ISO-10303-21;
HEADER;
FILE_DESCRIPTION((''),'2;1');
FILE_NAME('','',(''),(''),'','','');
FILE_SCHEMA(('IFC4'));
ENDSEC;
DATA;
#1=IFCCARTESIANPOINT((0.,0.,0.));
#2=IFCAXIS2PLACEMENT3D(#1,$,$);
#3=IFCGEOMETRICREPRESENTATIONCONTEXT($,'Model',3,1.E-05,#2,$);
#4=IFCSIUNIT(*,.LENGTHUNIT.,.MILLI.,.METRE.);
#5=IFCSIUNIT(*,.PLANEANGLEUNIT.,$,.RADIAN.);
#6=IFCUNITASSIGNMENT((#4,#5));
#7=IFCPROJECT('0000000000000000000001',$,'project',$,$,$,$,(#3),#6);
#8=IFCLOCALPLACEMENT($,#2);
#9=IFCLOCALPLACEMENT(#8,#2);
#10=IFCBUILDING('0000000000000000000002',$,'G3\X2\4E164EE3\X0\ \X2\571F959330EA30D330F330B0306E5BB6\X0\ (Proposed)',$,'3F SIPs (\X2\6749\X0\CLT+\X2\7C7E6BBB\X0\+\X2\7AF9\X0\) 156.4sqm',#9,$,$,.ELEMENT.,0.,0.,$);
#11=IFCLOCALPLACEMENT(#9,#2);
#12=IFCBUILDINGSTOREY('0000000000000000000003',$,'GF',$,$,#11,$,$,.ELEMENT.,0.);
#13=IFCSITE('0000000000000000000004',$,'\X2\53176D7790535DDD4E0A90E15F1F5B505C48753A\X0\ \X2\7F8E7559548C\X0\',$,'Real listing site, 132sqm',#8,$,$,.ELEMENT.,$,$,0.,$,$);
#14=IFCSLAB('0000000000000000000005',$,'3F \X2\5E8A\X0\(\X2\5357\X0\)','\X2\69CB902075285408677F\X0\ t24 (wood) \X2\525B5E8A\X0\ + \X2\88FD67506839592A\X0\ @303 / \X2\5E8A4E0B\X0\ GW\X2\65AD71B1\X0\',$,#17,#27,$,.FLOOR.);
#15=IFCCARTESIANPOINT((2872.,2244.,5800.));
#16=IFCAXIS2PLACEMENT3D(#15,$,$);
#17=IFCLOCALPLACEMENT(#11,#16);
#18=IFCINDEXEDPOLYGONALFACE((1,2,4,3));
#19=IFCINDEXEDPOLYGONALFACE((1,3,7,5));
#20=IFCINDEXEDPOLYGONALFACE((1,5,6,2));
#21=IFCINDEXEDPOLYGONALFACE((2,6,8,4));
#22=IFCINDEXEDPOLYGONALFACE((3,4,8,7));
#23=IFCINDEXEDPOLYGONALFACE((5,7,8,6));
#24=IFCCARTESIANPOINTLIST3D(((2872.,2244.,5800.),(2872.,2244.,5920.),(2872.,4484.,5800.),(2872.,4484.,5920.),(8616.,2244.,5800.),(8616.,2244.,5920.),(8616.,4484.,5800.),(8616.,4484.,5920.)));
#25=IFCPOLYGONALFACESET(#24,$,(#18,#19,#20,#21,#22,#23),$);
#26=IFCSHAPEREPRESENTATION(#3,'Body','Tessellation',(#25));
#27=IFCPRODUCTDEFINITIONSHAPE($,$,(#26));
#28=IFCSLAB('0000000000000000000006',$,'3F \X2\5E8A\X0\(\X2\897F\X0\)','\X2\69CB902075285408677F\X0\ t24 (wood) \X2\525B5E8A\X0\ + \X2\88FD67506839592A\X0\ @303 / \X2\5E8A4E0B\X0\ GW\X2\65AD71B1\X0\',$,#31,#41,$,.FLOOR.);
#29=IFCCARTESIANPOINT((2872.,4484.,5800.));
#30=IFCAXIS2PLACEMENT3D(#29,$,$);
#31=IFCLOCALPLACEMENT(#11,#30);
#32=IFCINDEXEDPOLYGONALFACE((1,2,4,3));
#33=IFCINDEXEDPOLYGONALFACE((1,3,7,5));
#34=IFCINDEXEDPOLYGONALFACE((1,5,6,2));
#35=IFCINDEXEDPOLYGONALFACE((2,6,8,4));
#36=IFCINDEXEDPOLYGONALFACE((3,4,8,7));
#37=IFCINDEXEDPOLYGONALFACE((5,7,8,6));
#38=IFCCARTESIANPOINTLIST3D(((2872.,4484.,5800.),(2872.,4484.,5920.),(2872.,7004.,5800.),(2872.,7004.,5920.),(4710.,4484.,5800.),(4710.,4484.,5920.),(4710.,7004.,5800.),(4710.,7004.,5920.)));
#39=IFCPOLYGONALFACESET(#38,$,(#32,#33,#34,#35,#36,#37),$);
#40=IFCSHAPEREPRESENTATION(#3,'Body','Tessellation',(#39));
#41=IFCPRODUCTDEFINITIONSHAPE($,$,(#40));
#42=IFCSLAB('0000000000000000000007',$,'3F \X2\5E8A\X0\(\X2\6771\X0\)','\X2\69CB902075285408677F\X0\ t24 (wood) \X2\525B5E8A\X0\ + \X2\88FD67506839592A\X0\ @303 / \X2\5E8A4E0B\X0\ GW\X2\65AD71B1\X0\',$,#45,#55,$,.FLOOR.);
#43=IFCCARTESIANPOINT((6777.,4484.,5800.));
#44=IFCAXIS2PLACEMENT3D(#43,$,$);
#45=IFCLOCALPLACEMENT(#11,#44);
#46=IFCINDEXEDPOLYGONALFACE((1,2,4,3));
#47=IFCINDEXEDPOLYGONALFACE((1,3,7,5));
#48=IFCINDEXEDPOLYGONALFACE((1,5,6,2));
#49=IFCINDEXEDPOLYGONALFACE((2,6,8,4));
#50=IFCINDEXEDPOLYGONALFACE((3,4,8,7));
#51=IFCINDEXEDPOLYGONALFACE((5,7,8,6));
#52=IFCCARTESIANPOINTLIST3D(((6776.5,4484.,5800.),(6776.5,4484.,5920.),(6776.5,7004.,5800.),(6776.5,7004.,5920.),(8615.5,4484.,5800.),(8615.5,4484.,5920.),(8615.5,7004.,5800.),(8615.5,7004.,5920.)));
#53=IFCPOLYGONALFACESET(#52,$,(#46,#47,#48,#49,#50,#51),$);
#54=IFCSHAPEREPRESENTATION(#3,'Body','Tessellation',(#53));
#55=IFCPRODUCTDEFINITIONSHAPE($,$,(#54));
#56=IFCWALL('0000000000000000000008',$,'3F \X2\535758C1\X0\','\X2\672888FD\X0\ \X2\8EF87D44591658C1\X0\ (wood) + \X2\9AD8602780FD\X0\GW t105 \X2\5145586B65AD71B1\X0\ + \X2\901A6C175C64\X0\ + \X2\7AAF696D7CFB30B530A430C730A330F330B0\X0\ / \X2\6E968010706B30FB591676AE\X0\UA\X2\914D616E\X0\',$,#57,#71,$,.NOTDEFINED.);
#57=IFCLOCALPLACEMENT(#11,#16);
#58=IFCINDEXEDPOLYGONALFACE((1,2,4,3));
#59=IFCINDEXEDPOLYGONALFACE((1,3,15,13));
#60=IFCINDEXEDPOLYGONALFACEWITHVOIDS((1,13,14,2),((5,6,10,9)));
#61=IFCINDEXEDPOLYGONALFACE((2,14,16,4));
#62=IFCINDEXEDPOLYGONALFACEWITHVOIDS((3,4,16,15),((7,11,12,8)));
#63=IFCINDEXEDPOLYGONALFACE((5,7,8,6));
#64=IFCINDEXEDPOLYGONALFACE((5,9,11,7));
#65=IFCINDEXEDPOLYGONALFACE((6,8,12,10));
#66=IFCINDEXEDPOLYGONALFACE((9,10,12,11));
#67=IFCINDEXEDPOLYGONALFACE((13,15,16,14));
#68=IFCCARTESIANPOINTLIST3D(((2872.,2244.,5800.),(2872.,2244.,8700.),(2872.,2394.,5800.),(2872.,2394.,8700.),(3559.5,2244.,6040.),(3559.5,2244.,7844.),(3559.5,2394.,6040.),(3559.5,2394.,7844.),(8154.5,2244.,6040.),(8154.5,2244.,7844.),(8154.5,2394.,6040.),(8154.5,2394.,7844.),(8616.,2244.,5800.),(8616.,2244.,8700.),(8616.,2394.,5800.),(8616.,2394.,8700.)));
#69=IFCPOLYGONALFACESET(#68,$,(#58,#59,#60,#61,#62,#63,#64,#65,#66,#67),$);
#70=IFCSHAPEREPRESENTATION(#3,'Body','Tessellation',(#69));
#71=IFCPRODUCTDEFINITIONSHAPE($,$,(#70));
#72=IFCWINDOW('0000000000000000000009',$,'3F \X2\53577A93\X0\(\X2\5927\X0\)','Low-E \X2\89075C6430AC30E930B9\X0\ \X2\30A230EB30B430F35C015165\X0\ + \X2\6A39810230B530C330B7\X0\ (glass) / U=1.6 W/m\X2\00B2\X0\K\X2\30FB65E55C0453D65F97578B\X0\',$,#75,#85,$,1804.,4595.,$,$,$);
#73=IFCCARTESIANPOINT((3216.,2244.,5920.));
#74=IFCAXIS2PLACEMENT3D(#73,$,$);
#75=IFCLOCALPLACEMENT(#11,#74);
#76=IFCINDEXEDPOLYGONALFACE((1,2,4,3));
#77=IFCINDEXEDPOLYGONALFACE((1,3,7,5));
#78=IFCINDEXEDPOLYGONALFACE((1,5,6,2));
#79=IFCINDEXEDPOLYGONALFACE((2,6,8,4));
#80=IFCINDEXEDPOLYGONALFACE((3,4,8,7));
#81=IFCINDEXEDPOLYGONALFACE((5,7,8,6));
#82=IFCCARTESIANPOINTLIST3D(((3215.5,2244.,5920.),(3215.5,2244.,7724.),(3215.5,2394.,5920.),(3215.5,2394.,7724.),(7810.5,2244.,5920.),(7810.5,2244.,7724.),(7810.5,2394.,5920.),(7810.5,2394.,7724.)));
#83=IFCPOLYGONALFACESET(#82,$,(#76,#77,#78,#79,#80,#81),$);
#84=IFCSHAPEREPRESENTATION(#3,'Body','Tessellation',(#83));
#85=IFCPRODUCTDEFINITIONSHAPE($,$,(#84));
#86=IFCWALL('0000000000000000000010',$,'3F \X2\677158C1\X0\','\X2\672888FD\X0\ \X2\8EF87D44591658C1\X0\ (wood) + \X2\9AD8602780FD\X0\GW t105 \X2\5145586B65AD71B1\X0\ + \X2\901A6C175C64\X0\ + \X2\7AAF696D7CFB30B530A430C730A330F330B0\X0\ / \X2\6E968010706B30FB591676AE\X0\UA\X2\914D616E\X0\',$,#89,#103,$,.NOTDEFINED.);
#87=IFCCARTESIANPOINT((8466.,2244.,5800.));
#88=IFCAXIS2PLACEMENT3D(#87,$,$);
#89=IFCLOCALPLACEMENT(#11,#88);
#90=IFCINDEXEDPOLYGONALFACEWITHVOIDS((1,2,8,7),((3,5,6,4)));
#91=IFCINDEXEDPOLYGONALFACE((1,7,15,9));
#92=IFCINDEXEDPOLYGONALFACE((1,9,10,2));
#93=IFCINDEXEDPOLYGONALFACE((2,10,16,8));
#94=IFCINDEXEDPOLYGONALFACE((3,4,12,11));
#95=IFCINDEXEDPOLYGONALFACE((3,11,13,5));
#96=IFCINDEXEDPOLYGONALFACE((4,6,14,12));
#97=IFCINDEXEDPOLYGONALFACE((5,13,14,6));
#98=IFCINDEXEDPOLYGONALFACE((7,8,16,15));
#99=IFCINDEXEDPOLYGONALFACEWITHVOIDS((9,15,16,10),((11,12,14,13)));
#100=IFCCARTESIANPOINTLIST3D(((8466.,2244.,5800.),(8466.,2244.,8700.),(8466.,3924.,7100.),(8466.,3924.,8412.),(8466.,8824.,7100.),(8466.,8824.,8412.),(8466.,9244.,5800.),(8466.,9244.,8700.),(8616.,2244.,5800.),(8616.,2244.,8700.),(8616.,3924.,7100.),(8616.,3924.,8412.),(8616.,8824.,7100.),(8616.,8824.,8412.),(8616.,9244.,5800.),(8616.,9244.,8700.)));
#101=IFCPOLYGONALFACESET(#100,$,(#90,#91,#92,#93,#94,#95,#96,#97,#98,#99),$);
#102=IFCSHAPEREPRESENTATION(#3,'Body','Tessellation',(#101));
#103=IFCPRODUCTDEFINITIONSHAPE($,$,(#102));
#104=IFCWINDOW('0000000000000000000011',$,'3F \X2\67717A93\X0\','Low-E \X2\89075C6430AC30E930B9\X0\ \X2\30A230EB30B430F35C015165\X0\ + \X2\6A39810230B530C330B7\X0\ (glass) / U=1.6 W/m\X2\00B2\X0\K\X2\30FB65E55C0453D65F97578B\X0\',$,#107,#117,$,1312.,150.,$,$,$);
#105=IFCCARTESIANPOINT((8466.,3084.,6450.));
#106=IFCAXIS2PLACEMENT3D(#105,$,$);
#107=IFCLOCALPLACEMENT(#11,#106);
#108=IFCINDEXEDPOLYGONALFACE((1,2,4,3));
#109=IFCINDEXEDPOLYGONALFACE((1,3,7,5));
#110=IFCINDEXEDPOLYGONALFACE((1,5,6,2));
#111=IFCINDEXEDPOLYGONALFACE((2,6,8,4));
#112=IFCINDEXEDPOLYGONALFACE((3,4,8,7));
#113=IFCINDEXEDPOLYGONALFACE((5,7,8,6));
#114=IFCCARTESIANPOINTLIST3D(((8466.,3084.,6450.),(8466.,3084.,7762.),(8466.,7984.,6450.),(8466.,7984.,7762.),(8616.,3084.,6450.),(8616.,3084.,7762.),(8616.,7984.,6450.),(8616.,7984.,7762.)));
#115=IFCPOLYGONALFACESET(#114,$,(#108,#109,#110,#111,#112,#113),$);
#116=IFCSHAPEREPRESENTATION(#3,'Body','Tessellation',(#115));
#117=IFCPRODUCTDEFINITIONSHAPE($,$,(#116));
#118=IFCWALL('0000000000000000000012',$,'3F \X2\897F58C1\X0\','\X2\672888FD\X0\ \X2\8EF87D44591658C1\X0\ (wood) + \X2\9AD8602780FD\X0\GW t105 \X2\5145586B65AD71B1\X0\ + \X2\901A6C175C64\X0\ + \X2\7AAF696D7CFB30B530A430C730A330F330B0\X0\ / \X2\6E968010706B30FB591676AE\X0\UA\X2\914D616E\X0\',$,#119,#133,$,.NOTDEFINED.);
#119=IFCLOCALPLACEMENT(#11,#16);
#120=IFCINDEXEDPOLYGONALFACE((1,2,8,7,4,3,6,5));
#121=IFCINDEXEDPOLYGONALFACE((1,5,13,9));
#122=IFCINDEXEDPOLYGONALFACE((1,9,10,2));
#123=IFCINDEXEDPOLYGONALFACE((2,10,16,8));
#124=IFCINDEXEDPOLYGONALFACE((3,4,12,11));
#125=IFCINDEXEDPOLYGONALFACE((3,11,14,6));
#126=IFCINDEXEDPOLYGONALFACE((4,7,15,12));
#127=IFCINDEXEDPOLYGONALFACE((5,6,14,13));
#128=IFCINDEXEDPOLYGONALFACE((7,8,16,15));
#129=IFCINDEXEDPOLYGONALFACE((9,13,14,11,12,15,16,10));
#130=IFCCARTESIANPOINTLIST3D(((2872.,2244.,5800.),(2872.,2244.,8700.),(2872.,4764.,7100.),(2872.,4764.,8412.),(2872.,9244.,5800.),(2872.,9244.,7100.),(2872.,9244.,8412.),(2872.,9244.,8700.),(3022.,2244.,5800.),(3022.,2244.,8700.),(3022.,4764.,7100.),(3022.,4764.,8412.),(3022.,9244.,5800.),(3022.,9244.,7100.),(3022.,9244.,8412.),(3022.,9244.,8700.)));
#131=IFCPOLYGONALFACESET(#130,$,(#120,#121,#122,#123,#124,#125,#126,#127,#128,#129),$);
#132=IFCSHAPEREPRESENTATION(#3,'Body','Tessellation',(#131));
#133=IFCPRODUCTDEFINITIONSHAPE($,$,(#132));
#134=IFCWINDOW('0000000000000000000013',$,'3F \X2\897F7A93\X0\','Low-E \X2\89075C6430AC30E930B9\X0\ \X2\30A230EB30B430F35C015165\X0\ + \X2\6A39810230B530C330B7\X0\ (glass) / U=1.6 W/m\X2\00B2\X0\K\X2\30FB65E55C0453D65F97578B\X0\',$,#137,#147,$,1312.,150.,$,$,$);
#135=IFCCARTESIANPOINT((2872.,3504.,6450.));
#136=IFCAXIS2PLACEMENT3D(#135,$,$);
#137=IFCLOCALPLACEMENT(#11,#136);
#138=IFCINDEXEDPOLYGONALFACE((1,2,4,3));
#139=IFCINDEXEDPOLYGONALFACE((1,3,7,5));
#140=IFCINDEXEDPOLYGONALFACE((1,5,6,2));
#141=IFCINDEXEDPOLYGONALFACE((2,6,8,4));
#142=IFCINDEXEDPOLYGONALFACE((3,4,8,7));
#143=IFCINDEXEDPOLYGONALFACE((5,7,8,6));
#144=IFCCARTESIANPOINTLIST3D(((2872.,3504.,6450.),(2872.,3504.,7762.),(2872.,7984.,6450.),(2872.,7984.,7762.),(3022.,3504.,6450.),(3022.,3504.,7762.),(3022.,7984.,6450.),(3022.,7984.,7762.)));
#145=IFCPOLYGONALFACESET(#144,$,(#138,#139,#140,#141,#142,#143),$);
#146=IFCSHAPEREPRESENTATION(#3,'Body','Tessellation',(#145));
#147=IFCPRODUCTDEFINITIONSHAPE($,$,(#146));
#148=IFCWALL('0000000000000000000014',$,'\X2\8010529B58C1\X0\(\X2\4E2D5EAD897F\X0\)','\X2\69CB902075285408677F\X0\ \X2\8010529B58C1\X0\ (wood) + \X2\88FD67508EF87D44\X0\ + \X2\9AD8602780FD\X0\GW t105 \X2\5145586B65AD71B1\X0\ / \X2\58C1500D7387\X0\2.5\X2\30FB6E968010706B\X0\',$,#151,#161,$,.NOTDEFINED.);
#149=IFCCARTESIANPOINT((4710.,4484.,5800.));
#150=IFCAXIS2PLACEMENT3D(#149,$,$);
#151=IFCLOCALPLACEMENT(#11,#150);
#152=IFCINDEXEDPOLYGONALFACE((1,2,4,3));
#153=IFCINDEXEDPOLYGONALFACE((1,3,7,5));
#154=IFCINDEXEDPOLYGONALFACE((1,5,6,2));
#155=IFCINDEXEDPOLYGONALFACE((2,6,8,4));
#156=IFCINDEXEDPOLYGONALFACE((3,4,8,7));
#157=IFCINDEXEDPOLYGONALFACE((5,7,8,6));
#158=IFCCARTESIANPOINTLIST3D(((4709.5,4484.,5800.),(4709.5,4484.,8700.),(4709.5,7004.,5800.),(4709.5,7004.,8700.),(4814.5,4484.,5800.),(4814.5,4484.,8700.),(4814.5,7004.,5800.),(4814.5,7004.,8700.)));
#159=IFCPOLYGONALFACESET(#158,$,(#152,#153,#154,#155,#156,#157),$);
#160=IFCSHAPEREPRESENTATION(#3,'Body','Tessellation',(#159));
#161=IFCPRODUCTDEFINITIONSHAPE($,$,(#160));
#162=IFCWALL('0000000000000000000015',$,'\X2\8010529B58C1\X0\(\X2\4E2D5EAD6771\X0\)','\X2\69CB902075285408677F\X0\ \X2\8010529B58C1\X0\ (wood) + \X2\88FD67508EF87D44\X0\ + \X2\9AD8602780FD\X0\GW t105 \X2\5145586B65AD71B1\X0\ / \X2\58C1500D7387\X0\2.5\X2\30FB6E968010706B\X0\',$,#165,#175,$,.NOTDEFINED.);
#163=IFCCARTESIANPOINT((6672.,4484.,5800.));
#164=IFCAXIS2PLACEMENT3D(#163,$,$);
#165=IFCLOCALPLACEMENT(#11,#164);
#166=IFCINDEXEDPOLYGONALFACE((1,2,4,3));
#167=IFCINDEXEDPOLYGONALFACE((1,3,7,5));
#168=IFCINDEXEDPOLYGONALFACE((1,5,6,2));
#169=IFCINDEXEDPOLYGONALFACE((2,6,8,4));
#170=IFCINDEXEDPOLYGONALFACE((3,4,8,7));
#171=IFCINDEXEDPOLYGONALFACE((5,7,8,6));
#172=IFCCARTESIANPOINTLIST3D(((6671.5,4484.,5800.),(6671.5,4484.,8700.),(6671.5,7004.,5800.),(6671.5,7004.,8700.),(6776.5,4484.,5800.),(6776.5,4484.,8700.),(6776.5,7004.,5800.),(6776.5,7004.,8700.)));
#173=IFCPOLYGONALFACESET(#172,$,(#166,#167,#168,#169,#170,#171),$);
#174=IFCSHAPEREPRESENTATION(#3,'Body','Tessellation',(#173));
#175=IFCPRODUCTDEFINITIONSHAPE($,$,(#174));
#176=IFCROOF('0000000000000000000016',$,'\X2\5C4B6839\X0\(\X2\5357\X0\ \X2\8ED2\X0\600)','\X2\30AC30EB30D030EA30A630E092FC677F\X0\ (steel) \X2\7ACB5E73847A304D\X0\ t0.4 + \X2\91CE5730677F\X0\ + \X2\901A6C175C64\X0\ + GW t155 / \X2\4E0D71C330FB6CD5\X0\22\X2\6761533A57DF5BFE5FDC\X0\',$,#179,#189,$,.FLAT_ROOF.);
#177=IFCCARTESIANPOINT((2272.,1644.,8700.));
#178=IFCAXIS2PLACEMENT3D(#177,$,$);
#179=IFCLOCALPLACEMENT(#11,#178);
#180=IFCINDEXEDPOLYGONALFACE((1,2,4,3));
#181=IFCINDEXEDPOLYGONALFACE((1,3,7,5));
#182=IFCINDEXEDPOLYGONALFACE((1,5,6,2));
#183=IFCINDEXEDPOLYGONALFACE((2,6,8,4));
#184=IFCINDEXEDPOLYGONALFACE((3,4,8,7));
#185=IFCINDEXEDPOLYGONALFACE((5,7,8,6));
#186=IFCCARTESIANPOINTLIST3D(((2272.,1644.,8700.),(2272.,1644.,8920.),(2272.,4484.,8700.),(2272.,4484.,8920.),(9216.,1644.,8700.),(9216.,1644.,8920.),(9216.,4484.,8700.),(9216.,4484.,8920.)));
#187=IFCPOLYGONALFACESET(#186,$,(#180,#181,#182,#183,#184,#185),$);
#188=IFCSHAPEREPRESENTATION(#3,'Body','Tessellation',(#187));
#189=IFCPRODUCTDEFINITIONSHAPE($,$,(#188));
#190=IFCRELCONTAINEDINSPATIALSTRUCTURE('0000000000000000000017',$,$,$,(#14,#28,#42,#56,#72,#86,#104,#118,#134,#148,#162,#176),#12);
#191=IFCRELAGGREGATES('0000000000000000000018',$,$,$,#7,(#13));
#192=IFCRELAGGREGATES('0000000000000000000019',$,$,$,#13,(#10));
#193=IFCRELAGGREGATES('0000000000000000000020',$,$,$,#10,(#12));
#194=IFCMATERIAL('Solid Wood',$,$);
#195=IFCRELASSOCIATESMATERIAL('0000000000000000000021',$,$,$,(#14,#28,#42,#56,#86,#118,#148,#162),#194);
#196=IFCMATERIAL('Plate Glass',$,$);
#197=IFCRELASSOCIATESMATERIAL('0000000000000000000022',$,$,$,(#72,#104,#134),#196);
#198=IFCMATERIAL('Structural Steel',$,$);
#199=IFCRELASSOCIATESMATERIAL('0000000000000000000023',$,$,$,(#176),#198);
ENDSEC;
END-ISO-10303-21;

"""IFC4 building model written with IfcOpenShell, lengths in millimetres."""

from ifc_helpers import new_model, si_unit, frame, frame_2d, origin, place, context, project, spatial, rectangle, extrude, material, element, fill, save


model = new_model("IFC4")

# Units and contexts
model_context = context("Model", 3, precision=1e-05, world=origin())
ifc_project = project(units=[si_unit("LENGTHUNIT", "METRE", prefix="MILLI"), si_unit("PLANEANGLEUNIT", "RADIAN")], contexts=[model_context])

# Site, building, storey
site_placement = place(None, origin())
site = spatial("IfcSite", under=ifc_project, at=site_placement, Name="北海道川上郡弟子屈町 美留和", ObjectType="Real listing site, 132sqm", CompositionType="ELEMENT", RefElevation=0.0)
building_placement = place(site_placement, origin())
building = spatial("IfcBuilding", under=site, at=building_placement, Name="G3世代 土間リビングの家 (Proposed)", ObjectType="3F SIPs (杉CLT+籾殻+竹) 156.4sqm", CompositionType="ELEMENT", ElevationOfRefHeight=0.0, ElevationOfTerrain=0.0)
storey_placement = place(building_placement, origin())
storey = spatial("IfcBuildingStorey", under=building, at=storey_placement, Name="GF", CompositionType="ELEMENT", Elevation=0.0)

# Slabs
ifc_material_1 = material(Name="Solid Wood")
slab_1_placement = place(storey_placement, frame((2872.0, 2244.0, 5800.0)))
element("IfcSlab", 1, at=slab_1_placement, inside=storey, material=ifc_material_1, Name="3F 床(南)", Description="構造用合板 t24 (wood) 剛床 + 製材根太 @303 / 床下 GW断熱", PredefinedType="FLOOR", context=model_context, shape_type="SweptSolid", body=[
    extrude(rectangle(XDim=5744.0, YDim=2240.0, at=frame_2d((2872.0, 1120.0))), frame((2872.0, 2244.0, 5800.0)), (0.0, 0.0, 1.0), 120.0),
])
slab_2_placement = place(storey_placement, frame((2872.0, 4484.0, 5800.0)))
element("IfcSlab", 2, at=slab_2_placement, inside=storey, material=ifc_material_1, Name="3F 床(西)", Description="構造用合板 t24 (wood) 剛床 + 製材根太 @303 / 床下 GW断熱", PredefinedType="FLOOR", context=model_context, shape_type="SweptSolid", body=[
    extrude(rectangle(XDim=1838.0, YDim=2520.0, at=frame_2d((919.0, 1260.0))), frame((2872.0, 4484.0, 5800.0)), (0.0, 0.0, 1.0), 120.0),
])
slab_3_placement = place(storey_placement, frame((6777.0, 4484.0, 5800.0)))
element("IfcSlab", 3, at=slab_3_placement, inside=storey, material=ifc_material_1, Name="3F 床(東)", Description="構造用合板 t24 (wood) 剛床 + 製材根太 @303 / 床下 GW断熱", PredefinedType="FLOOR", context=model_context, shape_type="SweptSolid", body=[
    extrude(rectangle(XDim=1839.0, YDim=2520.0, at=frame_2d((919.0, 1260.0))), frame((6777.0, 4484.0, 5800.0)), (0.0, 0.0, 1.0), 120.0),
])

# Walls, openings, windows
wall_1_placement = place(storey_placement, frame((2872.0, 2244.0, 5800.0)))
wall_1 = element("IfcWall", 4, at=wall_1_placement, inside=storey, material=ifc_material_1, Name="3F 南壁", Description="木製 軸組外壁 (wood) + 高性能GW t105 充填断熱 + 通気層 + 窯業系サイディング / 準耐火・外皮UA配慮", PredefinedType="NOTDEFINED", context=model_context, shape_type="SweptSolid", body=[
    extrude(rectangle(XDim=5744.0, YDim=150.0, at=frame_2d((2872.0, 75.0))), frame((2872.0, 2244.0, 5800.0)), (0.0, 0.0, 1.0), 2900.0),
])
opening_1_placement = place(storey_placement, frame((3216.0, 2244.0, 5920.0)))
opening_1 = element("IfcOpeningElement", 5, at=opening_1_placement, cuts=wall_1, PredefinedType="NOTDEFINED", context=model_context, shape_type="SweptSolid", body=[
    extrude(rectangle(XDim=4595.0, YDim=150.0, at=frame_2d((2297.0, 75.0))), frame((3216.0, 2244.0, 5920.0)), (0.0, 0.0, 1.0), 1804.0),
])
ifc_material_2 = material(Name="Plate Glass")
window_1_placement = place(storey_placement, frame((3216.0, 2244.0, 5920.0)))
window_1 = element("IfcWindow", 6, at=window_1_placement, inside=storey, material=ifc_material_2, Name="3F 南窓(大)", Description="Low-E 複層ガラス アルゴン封入 + 樹脂サッシ (glass) / U=1.6 W/m²K・日射取得型", OverallHeight=1804.0, OverallWidth=4595.0, context=model_context, shape_type="SweptSolid", body=[
    extrude(rectangle(XDim=4595.0, YDim=150.0, at=frame_2d((2297.0, 75.0))), frame((3216.0, 2244.0, 5920.0)), (0.0, 0.0, 1.0), 1804.0),
])
fill(opening_1, window_1)
wall_2_placement = place(storey_placement, frame((8466.0, 2244.0, 5800.0)))
wall_2 = element("IfcWall", 7, at=wall_2_placement, inside=storey, material=ifc_material_1, Name="3F 東壁", Description="木製 軸組外壁 (wood) + 高性能GW t105 充填断熱 + 通気層 + 窯業系サイディング / 準耐火・外皮UA配慮", PredefinedType="NOTDEFINED", context=model_context, shape_type="SweptSolid", body=[
    extrude(rectangle(XDim=150.0, YDim=7000.0, at=frame_2d((75.0, 3500.0))), frame((8466.0, 2244.0, 5800.0)), (0.0, 0.0, 1.0), 2900.0),
])
opening_2_placement = place(storey_placement, frame((8466.0, 3084.0, 6450.0)))
opening_2 = element("IfcOpeningElement", 8, at=opening_2_placement, cuts=wall_2, PredefinedType="NOTDEFINED", context=model_context, shape_type="SweptSolid", body=[
    extrude(rectangle(XDim=150.0, YDim=4900.0, at=frame_2d((75.0, 2450.0))), frame((8466.0, 3084.0, 6450.0)), (0.0, 0.0, 1.0), 1312.0),
])
window_2_placement = place(storey_placement, frame((8466.0, 3084.0, 6450.0)))
window_2 = element("IfcWindow", 9, at=window_2_placement, inside=storey, material=ifc_material_2, Name="3F 東窓", Description="Low-E 複層ガラス アルゴン封入 + 樹脂サッシ (glass) / U=1.6 W/m²K・日射取得型", OverallHeight=1312.0, OverallWidth=150.0, context=model_context, shape_type="SweptSolid", body=[
    extrude(rectangle(XDim=150.0, YDim=4900.0, at=frame_2d((75.0, 2450.0))), frame((8466.0, 3084.0, 6450.0)), (0.0, 0.0, 1.0), 1312.0),
])
fill(opening_2, window_2)
wall_3_placement = place(storey_placement, frame((2872.0, 2244.0, 5800.0)))
wall_3 = element("IfcWall", 10, at=wall_3_placement, inside=storey, material=ifc_material_1, Name="3F 西壁", Description="木製 軸組外壁 (wood) + 高性能GW t105 充填断熱 + 通気層 + 窯業系サイディング / 準耐火・外皮UA配慮", PredefinedType="NOTDEFINED", context=model_context, shape_type="SweptSolid", body=[
    extrude(rectangle(XDim=150.0, YDim=7000.0, at=frame_2d((75.0, 3500.0))), frame((2872.0, 2244.0, 5800.0)), (0.0, 0.0, 1.0), 2900.0),
])
opening_3_placement = place(storey_placement, frame((2872.0, 3504.0, 6450.0)))
opening_3 = element("IfcOpeningElement", 11, at=opening_3_placement, cuts=wall_3, PredefinedType="NOTDEFINED", context=model_context, shape_type="SweptSolid", body=[
    extrude(rectangle(XDim=150.0, YDim=4480.0, at=frame_2d((75.0, 2240.0))), frame((2872.0, 3504.0, 6450.0)), (0.0, 0.0, 1.0), 1312.0),
])
window_3_placement = place(storey_placement, frame((2872.0, 3504.0, 6450.0)))
window_3 = element("IfcWindow", 12, at=window_3_placement, inside=storey, material=ifc_material_2, Name="3F 西窓", Description="Low-E 複層ガラス アルゴン封入 + 樹脂サッシ (glass) / U=1.6 W/m²K・日射取得型", OverallHeight=1312.0, OverallWidth=150.0, context=model_context, shape_type="SweptSolid", body=[
    extrude(rectangle(XDim=150.0, YDim=4480.0, at=frame_2d((75.0, 2240.0))), frame((2872.0, 3504.0, 6450.0)), (0.0, 0.0, 1.0), 1312.0),
])
fill(opening_3, window_3)

# Walls
wall_4_placement = place(storey_placement, frame((4710.0, 4484.0, 5800.0)))
element("IfcWall", 13, at=wall_4_placement, inside=storey, material=ifc_material_1, Name="耐力壁(中庭西)", Description="構造用合板 耐力壁 (wood) + 製材軸組 + 高性能GW t105 充填断熱 / 壁倍率2.5・準耐火", PredefinedType="NOTDEFINED", context=model_context, shape_type="SweptSolid", body=[
    extrude(rectangle(XDim=105.0, YDim=2520.0, at=frame_2d((52.0, 1260.0))), frame((4710.0, 4484.0, 5800.0)), (0.0, 0.0, 1.0), 2900.0),
])
wall_5_placement = place(storey_placement, frame((6672.0, 4484.0, 5800.0)))
element("IfcWall", 14, at=wall_5_placement, inside=storey, material=ifc_material_1, Name="耐力壁(中庭東)", Description="構造用合板 耐力壁 (wood) + 製材軸組 + 高性能GW t105 充填断熱 / 壁倍率2.5・準耐火", PredefinedType="NOTDEFINED", context=model_context, shape_type="SweptSolid", body=[
    extrude(rectangle(XDim=105.0, YDim=2520.0, at=frame_2d((52.0, 1260.0))), frame((6672.0, 4484.0, 5800.0)), (0.0, 0.0, 1.0), 2900.0),
])

# Roof
ifc_material_3 = material(Name="Structural Steel")
roof_1_placement = place(storey_placement, frame((2272.0, 1644.0, 8700.0)))
element("IfcRoof", 15, at=roof_1_placement, inside=storey, material=ifc_material_3, Name="屋根(南 軒600)", Description="ガルバリウム鋼板 (steel) 立平葺き t0.4 + 野地板 + 通気層 + GW t155 / 不燃・法22条区域対応", PredefinedType="FLAT_ROOF", context=model_context, shape_type="SweptSolid", body=[
    extrude(rectangle(XDim=6944.0, YDim=2840.0, at=frame_2d((3472.0, 1420.0))), frame((2272.0, 1644.0, 8700.0)), (0.0, 0.0, 1.0), 220.0),
])

save(model, "model.ifc")
